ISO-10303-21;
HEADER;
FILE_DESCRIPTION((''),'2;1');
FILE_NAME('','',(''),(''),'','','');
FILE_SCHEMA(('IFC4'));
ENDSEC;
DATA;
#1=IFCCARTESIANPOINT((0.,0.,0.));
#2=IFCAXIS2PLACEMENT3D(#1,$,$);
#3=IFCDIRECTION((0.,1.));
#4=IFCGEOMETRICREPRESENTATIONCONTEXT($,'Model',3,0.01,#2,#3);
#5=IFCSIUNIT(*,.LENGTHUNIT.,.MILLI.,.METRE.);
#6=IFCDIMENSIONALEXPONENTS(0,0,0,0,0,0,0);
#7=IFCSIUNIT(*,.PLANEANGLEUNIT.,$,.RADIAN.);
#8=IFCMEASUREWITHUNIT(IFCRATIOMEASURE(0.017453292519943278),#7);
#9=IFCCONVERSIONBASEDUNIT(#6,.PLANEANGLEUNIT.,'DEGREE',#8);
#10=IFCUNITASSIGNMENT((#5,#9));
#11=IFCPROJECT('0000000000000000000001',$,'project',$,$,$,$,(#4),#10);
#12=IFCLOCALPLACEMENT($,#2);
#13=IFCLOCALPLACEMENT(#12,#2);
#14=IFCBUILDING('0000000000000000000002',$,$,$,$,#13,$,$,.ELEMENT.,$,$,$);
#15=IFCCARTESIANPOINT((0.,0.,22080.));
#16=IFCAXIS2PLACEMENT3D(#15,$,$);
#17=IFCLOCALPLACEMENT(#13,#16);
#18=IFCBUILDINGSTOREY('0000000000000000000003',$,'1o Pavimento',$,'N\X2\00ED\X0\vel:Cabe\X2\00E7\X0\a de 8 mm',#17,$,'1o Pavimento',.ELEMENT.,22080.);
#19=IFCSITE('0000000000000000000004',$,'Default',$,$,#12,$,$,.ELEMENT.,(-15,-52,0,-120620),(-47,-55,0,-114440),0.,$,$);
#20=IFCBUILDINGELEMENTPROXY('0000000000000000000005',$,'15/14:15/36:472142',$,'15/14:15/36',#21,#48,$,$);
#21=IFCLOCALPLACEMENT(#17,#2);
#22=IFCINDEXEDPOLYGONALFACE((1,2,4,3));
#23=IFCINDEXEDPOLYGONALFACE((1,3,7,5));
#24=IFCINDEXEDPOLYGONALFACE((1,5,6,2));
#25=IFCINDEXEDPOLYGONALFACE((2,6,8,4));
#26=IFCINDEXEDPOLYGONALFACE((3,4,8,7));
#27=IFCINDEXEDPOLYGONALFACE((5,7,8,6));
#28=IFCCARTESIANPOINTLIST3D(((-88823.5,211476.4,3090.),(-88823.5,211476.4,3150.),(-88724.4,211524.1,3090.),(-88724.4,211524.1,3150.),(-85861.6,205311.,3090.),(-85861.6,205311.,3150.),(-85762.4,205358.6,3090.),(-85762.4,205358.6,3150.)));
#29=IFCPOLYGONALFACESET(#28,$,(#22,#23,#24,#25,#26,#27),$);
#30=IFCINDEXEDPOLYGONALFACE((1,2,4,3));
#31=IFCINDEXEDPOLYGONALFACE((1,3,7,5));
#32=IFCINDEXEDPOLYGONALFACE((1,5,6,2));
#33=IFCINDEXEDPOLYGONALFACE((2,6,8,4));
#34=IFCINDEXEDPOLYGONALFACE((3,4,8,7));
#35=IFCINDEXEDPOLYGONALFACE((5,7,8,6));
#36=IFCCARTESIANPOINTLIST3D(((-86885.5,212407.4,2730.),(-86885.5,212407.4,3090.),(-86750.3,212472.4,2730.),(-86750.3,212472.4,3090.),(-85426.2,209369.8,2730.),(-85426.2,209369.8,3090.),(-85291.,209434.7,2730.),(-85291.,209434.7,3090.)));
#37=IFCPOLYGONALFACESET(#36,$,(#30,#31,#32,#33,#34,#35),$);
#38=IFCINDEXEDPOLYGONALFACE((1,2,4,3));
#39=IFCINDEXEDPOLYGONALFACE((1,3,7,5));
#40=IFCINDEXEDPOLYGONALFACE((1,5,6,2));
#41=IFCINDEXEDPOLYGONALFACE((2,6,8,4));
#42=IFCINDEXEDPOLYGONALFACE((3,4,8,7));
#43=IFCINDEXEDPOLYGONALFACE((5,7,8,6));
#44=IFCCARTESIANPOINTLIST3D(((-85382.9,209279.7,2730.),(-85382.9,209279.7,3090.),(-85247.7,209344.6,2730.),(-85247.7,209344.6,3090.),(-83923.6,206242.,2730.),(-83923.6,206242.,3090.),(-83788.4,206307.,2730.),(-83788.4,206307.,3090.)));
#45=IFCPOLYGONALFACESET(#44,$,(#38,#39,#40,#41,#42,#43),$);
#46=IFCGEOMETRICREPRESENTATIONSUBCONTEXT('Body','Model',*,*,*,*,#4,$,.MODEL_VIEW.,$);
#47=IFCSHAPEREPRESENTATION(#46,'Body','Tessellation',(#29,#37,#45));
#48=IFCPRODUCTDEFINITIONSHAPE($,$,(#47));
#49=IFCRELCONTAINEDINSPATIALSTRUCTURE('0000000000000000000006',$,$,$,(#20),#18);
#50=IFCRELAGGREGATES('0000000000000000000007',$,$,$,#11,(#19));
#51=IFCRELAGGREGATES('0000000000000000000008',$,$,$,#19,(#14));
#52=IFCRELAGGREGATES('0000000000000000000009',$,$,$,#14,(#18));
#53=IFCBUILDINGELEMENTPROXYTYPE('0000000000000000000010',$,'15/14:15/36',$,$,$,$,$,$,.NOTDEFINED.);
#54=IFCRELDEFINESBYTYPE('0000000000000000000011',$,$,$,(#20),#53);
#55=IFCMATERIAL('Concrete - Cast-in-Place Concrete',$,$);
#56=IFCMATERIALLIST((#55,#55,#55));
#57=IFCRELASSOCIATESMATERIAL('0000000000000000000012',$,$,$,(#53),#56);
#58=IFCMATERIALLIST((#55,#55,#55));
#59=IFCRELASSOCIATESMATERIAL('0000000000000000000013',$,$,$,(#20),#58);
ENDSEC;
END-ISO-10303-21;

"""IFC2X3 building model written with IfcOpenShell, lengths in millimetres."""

from ifc_helpers import new_model, entity, si_unit, converted_unit, direction, frame, frame_2d, origin, place, context, subcontext, project, spatial, rectangle, extrude, source, transform, mapped, material, material_list, type_object, type_shapes, element, save


model = new_model("IFC2X3")

# Units and contexts
model_context = context("Model", 3, precision=0.01, world=origin(), true_north=direction((0.0, 1.0)))
body_context = subcontext(model_context, "Body", "Model", "MODEL_VIEW")
ifc_project = project(units=[si_unit("LENGTHUNIT", "METRE", prefix="MILLI"), converted_unit("PLANEANGLEUNIT", "DEGREE", entity("IfcRatioMeasure", 0.017453292519943278), si_unit("PLANEANGLEUNIT", "RADIAN"), dimensions=[0, 0, 0, 0, 0, 0, 0])], contexts=[model_context])

# Site, building, storey
site_placement = place(None, origin())
site = spatial("IfcSite", under=ifc_project, at=site_placement, Name="Default", CompositionType="ELEMENT", RefLatitude=(-15, -52, 0, -120620), RefLongitude=(-47, -55, 0, -114440), RefElevation=0.0)
building_placement = place(site_placement, origin())
building = spatial("IfcBuilding", under=site, at=building_placement, CompositionType="ELEMENT")
storey_placement = place(building_placement, frame((0.0, 0.0, 22080.0)))
storey = spatial("IfcBuildingStorey", under=building, at=storey_placement, Name="1o Pavimento", ObjectType="Nível:Cabeça de 8 mm", LongName="1o Pavimento", CompositionType="ELEMENT", Elevation=22080.0)

# Building element proxy
ifc_material_1 = material(Name="Concrete - Cast-in-Place Concrete")
ifc_material_list_1 = material_list([ifc_material_1, ifc_material_1, ifc_material_1])
ifc_material_list_2 = material_list([ifc_material_1, ifc_material_1, ifc_material_1])
building_element_proxy_type_1 = type_object("IfcBuildingElementProxyType", Name="15/14:15/36", PredefinedType="NOTDEFINED", material=ifc_material_list_2)
shared_shape_1 = source(origin(), body_context, "Body", "SweptSolid", [
    extrude(rectangle(XDim=110.0, YDim=6840.0, at=frame_2d((0.0, 0.0), x_axis=(1.0, 0.0))), frame((1530.5, 3106.5, 360.0), z_axis=(0.0, 0.0, 1.0), x_axis=(0.90138, 0.43303, 0.0)), (0.0, 0.0, 1.0), 60.0),
    extrude(rectangle(XDim=3370.0, YDim=150.0, at=frame_2d((0.0, 0.0), x_axis=(1.0, 0.0))), frame((2735.2, 5610.1, 0.0), z_axis=(0.0, 0.0, 1.0), x_axis=(0.43303, -0.90138, 0.0)), (0.0, 0.0, 1.0), 360.0),
    extrude(rectangle(XDim=3370.0, YDim=150.0, at=frame_2d((0.0, 0.0), x_axis=(1.0, 0.0))), frame((4237.8, 2482.3, 0.0), z_axis=(0.0, 0.0, 1.0), x_axis=(0.43303, -0.90138, 0.0)), (0.0, 0.0, 1.0), 360.0),
])
type_shapes(building_element_proxy_type_1, [shared_shape_1])
proxy_1_placement = place(storey_placement, frame((-88823.5, 205311.0, 2730.0)))
element("IfcBuildingElementProxy", 1, at=proxy_1_placement, inside=storey, type_object=building_element_proxy_type_1, material=ifc_material_list_1, Name="15/14:15/36:472142", ObjectType="15/14:15/36", context=body_context, shape_type="MappedRepresentation", body=[
    mapped(shared_shape_1, transform((0.0, 0.0, 0.0), scale=1.0)),
])

save(model, "model.ifc")
